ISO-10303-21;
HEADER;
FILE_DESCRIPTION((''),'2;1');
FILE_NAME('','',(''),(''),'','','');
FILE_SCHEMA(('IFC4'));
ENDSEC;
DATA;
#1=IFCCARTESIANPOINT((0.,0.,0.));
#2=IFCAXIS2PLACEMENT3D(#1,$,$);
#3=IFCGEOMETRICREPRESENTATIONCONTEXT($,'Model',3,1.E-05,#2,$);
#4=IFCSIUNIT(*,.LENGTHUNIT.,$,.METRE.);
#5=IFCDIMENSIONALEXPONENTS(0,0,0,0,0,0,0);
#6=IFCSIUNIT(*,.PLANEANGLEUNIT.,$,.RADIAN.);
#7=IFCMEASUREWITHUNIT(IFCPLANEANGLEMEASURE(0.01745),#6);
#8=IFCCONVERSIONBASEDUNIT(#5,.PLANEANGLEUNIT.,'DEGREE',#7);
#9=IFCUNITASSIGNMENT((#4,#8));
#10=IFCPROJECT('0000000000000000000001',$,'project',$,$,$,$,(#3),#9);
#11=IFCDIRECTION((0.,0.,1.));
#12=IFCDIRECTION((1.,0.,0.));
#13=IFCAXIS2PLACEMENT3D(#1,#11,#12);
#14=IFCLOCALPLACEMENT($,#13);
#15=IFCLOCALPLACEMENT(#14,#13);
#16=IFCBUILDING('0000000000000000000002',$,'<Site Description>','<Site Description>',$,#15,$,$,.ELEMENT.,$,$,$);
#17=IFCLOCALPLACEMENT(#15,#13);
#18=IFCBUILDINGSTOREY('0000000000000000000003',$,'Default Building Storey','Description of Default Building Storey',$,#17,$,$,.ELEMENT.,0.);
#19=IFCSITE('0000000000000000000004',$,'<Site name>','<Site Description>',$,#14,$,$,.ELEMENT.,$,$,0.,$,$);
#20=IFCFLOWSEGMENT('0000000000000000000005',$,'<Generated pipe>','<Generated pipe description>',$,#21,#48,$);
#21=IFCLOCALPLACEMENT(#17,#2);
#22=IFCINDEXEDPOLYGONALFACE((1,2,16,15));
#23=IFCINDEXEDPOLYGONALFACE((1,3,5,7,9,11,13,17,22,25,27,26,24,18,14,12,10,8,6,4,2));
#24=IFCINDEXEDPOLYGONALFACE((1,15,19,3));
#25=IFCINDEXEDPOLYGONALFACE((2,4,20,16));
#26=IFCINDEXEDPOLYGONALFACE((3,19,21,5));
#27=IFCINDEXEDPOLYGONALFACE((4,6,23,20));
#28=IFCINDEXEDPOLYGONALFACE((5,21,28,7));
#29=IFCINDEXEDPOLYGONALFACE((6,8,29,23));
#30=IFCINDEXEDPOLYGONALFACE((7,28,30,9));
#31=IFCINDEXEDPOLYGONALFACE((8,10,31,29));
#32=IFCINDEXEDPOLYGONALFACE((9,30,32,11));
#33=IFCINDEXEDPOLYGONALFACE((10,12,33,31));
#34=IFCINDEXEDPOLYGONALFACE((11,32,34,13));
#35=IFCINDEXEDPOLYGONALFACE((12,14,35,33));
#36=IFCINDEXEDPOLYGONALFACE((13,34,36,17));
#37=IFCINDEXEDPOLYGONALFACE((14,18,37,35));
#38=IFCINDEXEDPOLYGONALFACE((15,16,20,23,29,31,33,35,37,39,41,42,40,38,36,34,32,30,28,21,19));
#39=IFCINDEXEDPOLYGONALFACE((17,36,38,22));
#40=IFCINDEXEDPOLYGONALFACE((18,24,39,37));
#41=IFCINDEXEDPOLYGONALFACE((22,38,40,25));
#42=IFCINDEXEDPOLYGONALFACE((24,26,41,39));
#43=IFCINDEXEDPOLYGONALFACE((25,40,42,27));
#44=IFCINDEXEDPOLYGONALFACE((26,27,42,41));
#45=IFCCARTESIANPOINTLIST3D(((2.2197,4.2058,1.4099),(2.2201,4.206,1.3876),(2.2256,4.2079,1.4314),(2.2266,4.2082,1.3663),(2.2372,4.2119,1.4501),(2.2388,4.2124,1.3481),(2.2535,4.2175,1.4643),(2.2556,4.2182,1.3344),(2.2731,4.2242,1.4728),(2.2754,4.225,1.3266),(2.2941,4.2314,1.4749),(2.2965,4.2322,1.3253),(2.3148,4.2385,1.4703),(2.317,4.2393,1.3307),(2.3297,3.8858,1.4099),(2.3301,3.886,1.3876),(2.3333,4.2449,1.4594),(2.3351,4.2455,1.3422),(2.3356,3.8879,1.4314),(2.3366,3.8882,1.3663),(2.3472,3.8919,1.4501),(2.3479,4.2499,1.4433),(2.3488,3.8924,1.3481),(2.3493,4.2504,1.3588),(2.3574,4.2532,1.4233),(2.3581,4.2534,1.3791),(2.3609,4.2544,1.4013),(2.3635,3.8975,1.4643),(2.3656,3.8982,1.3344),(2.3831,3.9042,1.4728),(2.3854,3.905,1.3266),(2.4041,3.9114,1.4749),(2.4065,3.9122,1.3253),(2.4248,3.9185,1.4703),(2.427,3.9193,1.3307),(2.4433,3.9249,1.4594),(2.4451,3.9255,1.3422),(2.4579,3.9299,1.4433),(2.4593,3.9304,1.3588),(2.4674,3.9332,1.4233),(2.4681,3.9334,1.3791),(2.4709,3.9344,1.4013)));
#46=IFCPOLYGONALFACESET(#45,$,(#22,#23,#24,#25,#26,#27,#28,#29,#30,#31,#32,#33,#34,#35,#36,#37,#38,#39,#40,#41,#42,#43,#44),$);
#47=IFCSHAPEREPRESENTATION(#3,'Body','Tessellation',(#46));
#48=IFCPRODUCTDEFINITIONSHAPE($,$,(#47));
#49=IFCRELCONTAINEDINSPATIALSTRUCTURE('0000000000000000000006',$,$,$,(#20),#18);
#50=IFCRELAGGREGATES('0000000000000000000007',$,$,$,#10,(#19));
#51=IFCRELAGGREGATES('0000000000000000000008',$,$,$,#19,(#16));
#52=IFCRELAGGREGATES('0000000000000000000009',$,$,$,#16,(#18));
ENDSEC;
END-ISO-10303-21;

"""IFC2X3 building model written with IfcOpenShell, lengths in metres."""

from ifc_helpers import new_model, entity, si_unit, converted_unit, frame, origin, origin_with_axes, origin_2d_with_axis, place, context, project, spatial, circle, extrude, element, save


model = new_model("IFC2X3")

# Units and contexts
model_context = context("Model", 3, precision=1e-05, world=origin())
ifc_project = project(units=[si_unit("LENGTHUNIT", "METRE"), converted_unit("PLANEANGLEUNIT", "DEGREE", entity("IfcPlaneAngleMeasure", 0.01745), si_unit("PLANEANGLEUNIT", "RADIAN"), dimensions=[0, 0, 0, 0, 0, 0, 0])], contexts=[model_context])

# Site, building, storey
site_placement = place(None, origin_with_axes())
site = spatial("IfcSite", under=ifc_project, at=site_placement, Name="<Site name>", Description="<Site Description>", CompositionType="ELEMENT", RefElevation=0.0)
building_placement = place(site_placement, origin_with_axes())
building = spatial("IfcBuilding", under=site, at=building_placement, Name="<Site Description>", Description="<Site Description>", CompositionType="ELEMENT")
storey_placement = place(building_placement, origin_with_axes())
storey = spatial("IfcBuildingStorey", under=building, at=storey_placement, Name="Default Building Storey", Description="Description of Default Building Storey", CompositionType="ELEMENT", Elevation=0.0)

# Flow segment
flow_segment_1_placement = place(storey_placement, frame((2.4, 3.91, 1.4), z_axis=(-0.32508, 0.945687, 0.0), x_axis=(0.898899, 0.308996, 0.310648)))
element("IfcFlowSegment", 1, at=flow_segment_1_placement, inside=storey, Name="<Generated pipe>", Description="<Generated pipe description>", context=model_context, shape_type="SweptSolid", body=[
    extrude(circle(Radius=0.075, at=origin_2d_with_axis()), origin_with_axes(), (0.0, 0.0, 1.0), 0.3384),
])

save(model, "model.ifc")
